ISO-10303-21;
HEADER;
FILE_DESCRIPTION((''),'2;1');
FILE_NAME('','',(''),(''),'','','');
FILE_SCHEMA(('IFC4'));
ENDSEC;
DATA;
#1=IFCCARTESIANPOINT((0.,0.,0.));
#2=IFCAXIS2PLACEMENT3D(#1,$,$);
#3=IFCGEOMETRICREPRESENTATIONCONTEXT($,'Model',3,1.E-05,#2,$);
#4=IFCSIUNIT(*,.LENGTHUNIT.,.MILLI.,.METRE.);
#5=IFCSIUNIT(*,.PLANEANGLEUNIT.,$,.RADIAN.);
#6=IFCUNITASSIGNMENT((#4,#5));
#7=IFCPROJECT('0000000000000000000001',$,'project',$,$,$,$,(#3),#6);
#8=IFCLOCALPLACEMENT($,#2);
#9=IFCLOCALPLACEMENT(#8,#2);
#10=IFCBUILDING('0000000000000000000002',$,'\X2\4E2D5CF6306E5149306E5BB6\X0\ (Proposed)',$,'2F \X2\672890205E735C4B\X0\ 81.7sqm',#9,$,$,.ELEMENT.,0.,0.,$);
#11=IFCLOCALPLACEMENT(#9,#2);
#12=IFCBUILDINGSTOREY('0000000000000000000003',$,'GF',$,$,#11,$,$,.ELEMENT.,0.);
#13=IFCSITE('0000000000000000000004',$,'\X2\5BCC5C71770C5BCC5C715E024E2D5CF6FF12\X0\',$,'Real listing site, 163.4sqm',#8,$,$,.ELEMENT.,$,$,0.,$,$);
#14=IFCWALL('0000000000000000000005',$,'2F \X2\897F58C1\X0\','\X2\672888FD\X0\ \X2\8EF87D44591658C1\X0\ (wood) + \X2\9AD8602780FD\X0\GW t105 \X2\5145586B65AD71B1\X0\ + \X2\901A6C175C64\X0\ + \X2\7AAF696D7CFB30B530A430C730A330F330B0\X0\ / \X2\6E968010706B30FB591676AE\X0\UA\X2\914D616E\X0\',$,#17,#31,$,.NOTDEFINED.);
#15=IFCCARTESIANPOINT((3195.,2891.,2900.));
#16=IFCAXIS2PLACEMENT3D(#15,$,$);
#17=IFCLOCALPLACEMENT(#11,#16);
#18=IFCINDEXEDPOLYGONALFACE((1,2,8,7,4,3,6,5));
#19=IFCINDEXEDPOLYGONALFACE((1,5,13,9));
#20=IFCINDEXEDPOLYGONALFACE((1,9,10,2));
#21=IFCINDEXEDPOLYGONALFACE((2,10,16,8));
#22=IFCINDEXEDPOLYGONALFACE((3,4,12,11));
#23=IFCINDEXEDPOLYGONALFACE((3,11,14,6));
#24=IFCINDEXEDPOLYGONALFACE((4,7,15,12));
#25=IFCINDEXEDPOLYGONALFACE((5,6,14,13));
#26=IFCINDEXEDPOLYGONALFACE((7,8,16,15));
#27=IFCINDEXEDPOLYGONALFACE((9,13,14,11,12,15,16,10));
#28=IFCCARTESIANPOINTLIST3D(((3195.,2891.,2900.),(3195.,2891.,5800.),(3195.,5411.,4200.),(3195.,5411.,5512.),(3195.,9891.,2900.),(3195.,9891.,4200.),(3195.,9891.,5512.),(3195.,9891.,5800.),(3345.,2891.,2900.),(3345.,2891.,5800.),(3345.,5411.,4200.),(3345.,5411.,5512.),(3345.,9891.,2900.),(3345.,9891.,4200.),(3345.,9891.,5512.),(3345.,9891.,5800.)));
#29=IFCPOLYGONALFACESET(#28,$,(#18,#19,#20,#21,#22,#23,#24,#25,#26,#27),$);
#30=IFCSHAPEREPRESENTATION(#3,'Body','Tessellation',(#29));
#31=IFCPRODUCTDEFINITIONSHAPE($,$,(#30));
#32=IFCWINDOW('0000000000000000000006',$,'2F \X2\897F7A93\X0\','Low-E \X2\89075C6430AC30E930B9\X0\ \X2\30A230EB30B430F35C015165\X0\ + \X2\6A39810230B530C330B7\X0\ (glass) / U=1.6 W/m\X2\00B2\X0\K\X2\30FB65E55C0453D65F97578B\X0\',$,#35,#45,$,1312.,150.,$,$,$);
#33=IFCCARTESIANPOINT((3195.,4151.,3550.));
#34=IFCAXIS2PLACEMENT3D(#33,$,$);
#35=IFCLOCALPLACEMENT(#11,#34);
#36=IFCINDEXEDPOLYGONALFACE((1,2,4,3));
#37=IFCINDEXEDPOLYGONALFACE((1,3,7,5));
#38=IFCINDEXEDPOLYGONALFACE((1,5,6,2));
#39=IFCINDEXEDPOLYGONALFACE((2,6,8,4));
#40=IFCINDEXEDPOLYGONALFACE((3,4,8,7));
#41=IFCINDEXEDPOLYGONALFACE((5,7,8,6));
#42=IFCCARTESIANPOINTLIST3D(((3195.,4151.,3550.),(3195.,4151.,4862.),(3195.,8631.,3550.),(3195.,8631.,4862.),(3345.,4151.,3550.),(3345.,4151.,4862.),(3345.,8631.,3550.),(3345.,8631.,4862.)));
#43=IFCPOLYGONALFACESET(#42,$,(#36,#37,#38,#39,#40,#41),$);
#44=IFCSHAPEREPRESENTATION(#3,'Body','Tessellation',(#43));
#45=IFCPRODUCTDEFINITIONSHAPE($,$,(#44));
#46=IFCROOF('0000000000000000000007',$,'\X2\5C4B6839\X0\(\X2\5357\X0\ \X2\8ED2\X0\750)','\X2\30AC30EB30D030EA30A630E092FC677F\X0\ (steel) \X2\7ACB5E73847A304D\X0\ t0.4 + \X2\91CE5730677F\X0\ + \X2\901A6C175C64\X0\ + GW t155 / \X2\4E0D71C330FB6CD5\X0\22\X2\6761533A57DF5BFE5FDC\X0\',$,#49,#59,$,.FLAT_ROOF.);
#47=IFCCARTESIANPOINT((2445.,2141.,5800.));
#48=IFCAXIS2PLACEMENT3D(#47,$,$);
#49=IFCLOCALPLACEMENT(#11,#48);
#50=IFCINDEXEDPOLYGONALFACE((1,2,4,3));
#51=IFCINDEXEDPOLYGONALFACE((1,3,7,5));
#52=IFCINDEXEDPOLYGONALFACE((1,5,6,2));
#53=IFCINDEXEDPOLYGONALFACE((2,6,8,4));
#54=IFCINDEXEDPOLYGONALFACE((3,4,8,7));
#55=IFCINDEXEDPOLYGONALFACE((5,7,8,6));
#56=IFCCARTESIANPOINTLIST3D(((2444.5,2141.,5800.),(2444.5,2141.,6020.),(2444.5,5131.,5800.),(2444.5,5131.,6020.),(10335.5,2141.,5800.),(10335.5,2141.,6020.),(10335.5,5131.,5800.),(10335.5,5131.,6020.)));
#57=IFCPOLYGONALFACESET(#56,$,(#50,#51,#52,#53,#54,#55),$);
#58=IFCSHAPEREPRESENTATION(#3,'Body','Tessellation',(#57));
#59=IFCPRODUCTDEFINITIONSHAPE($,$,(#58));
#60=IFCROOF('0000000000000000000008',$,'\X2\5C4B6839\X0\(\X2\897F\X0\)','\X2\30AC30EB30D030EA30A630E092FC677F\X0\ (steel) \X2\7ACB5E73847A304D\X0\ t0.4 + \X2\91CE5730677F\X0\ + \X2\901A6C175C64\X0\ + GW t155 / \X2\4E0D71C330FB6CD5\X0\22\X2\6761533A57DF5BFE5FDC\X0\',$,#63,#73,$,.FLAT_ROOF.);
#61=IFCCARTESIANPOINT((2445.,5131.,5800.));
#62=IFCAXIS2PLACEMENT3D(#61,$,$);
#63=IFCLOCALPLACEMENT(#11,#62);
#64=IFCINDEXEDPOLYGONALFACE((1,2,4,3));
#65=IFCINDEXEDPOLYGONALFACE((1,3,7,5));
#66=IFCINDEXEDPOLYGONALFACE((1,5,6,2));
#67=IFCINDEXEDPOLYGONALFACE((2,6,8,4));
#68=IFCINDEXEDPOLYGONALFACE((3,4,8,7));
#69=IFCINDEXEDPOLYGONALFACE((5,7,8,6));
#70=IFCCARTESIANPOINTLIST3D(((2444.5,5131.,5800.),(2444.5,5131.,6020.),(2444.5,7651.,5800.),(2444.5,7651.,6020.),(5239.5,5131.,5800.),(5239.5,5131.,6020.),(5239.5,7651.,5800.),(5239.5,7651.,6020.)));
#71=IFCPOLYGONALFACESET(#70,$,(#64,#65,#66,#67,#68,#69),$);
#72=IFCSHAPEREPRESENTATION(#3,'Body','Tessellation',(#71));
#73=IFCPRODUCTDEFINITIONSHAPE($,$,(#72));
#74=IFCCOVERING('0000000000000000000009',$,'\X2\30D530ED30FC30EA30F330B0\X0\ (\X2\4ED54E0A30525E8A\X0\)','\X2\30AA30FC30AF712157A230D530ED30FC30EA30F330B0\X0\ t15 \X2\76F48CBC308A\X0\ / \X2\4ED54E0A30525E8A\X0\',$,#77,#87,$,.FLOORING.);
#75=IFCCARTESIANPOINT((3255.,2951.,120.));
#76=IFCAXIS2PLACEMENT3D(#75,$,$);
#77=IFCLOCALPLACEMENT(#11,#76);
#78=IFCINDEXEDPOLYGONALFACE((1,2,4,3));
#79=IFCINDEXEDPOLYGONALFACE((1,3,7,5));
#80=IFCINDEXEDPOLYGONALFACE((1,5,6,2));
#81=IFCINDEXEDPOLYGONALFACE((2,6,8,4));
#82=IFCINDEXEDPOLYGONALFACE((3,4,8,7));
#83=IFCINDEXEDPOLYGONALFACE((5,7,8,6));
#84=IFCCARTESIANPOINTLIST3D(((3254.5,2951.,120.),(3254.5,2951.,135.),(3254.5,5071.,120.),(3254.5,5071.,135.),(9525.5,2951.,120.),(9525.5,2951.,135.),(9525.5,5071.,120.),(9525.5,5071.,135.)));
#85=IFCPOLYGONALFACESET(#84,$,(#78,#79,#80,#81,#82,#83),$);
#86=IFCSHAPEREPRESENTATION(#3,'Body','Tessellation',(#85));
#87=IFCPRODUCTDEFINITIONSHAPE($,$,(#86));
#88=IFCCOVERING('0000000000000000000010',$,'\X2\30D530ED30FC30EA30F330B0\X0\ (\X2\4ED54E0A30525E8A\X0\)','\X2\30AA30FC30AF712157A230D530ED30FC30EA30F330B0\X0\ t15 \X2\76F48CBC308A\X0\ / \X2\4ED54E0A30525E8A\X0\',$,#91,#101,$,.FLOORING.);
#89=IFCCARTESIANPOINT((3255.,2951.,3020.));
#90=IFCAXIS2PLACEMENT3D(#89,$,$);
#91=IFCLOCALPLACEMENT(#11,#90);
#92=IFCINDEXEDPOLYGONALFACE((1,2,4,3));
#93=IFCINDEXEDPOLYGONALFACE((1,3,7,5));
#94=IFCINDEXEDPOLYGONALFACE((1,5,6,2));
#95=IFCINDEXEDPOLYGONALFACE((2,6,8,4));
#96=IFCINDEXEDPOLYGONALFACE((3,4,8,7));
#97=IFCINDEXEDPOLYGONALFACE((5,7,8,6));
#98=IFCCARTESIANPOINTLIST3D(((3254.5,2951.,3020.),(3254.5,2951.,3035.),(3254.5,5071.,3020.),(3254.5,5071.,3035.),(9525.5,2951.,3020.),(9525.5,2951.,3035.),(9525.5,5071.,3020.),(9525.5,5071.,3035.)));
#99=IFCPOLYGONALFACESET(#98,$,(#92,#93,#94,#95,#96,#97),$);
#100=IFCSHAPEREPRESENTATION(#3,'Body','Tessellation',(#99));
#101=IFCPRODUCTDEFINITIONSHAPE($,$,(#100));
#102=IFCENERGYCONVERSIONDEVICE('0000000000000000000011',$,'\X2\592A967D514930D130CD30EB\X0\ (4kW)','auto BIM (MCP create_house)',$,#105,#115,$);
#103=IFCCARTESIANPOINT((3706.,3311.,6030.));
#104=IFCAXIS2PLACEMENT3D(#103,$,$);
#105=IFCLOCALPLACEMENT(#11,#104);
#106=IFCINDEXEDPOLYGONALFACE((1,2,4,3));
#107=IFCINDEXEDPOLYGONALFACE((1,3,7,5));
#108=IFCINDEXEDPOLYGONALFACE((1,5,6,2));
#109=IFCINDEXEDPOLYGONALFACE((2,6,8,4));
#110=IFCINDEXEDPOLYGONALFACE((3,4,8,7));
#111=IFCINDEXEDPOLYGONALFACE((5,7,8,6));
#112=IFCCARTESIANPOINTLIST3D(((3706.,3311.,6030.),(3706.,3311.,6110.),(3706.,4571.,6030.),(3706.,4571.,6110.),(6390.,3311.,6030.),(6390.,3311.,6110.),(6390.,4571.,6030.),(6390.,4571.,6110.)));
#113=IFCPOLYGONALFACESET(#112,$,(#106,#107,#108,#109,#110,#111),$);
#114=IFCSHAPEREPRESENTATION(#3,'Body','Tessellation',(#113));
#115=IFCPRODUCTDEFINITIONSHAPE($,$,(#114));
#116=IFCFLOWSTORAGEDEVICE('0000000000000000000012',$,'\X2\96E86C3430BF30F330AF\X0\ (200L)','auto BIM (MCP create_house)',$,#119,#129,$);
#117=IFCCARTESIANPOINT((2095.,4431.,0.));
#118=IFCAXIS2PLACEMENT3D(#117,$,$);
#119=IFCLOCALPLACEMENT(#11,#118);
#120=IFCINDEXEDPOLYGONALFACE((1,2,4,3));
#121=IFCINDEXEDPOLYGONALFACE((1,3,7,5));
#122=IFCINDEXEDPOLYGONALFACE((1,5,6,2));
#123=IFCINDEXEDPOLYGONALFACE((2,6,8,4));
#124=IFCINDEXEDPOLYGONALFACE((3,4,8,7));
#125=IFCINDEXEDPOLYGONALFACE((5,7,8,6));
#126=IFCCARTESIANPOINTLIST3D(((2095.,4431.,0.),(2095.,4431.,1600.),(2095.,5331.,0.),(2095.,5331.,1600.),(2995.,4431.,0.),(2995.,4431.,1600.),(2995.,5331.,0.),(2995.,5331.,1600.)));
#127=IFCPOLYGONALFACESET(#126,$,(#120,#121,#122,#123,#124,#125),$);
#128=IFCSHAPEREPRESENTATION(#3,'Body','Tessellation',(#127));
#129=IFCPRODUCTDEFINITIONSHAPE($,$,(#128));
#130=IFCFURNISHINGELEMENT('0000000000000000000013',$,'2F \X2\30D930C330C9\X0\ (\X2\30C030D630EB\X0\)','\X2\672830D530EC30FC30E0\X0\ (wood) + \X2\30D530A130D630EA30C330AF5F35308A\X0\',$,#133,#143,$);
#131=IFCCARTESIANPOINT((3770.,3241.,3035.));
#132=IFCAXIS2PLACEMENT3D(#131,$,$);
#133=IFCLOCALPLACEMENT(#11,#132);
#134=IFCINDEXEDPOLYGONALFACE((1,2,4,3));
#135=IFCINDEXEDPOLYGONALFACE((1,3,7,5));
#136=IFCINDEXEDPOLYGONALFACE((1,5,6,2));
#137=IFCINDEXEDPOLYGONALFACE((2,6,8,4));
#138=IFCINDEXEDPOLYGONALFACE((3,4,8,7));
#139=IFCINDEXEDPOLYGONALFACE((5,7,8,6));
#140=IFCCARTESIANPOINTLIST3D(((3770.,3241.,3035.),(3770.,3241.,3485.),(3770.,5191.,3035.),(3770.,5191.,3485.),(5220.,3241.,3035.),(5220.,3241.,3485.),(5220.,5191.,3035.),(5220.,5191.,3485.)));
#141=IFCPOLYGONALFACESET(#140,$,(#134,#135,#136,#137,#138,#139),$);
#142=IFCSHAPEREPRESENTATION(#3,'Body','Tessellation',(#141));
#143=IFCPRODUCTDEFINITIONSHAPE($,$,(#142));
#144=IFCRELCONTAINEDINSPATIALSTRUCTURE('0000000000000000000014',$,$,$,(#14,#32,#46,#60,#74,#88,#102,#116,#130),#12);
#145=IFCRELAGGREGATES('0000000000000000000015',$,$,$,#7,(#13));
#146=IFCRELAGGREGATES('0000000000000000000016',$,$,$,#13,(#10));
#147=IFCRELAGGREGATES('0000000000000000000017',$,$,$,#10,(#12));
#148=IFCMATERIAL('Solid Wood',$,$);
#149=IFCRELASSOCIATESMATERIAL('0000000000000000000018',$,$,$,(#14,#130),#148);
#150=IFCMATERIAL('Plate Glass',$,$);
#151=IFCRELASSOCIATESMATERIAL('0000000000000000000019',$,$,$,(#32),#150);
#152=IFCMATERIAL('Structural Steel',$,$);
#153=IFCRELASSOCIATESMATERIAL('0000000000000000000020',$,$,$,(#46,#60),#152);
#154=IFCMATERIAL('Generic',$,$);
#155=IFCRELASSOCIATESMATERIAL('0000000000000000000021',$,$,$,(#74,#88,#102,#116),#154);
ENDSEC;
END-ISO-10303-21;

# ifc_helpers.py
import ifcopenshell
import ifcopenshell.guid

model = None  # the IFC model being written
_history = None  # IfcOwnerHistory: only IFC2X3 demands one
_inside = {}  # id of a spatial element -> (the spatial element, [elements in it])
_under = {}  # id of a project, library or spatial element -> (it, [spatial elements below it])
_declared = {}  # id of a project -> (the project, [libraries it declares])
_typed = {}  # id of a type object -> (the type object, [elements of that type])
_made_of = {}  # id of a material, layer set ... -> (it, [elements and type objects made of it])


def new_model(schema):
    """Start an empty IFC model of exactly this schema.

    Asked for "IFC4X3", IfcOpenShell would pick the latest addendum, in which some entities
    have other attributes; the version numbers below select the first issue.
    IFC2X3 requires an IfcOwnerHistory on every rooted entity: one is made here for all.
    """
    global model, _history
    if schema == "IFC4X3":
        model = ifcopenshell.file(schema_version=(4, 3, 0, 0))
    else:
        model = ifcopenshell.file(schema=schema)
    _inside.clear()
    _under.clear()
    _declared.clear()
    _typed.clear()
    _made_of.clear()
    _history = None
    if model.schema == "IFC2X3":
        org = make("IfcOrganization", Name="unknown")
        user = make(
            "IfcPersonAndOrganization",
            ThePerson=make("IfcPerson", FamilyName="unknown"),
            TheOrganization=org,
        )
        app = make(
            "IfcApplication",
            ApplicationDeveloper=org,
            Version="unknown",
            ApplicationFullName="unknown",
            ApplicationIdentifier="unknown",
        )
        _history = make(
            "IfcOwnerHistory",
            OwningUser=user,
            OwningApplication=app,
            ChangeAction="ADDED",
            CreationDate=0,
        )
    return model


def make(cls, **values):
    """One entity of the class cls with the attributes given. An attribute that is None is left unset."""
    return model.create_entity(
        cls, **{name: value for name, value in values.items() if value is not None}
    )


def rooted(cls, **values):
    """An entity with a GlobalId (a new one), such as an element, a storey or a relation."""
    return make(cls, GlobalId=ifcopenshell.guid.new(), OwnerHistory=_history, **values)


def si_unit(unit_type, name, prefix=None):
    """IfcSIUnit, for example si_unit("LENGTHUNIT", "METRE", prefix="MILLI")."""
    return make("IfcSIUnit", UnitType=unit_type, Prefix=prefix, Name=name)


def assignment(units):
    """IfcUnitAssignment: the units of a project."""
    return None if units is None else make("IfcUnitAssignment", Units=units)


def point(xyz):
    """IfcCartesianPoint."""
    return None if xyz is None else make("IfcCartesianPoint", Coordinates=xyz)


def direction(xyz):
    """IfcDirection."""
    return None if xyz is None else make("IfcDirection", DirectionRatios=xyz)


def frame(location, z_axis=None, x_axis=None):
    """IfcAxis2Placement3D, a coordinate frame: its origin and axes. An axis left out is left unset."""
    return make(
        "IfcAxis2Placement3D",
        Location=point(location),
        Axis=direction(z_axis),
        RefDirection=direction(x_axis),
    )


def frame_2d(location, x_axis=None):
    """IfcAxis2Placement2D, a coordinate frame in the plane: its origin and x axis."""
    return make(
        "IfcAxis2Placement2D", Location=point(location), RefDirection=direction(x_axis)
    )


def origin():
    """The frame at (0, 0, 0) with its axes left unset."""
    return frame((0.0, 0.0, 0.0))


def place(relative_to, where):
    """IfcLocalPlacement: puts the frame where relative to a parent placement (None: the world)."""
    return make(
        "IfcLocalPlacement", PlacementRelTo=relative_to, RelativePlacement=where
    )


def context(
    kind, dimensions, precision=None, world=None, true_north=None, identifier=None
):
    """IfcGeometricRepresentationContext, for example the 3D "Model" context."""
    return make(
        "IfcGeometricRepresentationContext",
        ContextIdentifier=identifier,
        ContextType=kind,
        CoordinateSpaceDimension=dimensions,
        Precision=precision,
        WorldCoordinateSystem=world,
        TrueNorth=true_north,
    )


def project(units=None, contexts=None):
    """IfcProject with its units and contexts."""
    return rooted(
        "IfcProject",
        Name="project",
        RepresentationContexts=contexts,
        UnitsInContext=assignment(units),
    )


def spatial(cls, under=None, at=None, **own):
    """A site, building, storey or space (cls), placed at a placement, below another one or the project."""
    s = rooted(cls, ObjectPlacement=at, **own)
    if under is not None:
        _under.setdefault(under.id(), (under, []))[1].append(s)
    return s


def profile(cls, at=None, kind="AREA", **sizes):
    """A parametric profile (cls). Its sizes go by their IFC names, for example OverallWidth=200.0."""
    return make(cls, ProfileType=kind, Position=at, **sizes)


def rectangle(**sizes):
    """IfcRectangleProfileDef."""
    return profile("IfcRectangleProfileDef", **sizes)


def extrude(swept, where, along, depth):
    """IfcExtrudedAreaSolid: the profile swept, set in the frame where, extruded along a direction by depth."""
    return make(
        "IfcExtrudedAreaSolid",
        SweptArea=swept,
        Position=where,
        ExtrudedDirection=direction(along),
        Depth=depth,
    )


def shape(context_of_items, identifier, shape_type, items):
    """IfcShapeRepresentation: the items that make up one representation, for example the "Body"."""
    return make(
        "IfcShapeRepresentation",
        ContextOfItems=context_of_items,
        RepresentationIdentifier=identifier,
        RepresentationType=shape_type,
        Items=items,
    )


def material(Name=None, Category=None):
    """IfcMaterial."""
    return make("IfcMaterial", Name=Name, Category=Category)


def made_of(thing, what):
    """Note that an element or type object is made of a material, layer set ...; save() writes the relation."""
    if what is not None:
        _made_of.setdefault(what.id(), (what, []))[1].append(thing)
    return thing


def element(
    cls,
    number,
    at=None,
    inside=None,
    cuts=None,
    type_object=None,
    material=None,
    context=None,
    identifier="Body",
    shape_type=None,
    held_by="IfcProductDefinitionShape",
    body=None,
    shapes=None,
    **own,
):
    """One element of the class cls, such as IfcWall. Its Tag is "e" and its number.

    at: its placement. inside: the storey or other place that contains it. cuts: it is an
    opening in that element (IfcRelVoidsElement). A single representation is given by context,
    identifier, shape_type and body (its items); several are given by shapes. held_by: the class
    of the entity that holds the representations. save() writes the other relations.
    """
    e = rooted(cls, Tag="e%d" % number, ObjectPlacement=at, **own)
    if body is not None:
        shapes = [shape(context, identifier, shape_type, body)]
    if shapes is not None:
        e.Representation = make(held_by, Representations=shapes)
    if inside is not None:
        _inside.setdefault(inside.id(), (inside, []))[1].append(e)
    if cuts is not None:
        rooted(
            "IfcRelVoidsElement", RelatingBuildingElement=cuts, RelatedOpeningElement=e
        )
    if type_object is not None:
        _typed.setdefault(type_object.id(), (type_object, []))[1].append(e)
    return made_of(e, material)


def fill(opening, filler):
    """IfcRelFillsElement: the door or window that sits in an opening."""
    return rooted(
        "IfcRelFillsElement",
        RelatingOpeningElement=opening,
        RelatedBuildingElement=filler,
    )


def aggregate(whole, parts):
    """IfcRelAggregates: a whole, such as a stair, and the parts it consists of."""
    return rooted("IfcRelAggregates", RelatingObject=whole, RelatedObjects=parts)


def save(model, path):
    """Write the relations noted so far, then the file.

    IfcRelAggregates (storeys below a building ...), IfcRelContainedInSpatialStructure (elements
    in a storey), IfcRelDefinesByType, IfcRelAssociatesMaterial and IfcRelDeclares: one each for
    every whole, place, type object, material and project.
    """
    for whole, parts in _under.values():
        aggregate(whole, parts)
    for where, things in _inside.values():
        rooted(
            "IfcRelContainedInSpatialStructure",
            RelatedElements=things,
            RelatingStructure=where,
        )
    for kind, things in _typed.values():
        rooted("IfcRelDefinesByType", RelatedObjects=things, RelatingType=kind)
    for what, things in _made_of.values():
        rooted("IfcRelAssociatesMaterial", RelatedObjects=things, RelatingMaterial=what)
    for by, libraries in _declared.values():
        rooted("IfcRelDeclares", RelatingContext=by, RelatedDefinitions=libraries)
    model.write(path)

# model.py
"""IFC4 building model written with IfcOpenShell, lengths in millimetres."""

from ifc_helpers import new_model, si_unit, frame, frame_2d, origin, place, context, project, spatial, rectangle, extrude, material, element, fill, save


model = new_model("IFC4")

# Units and contexts
model_context = context("Model", 3, precision=1e-05, world=origin())
ifc_project = project(units=[si_unit("LENGTHUNIT", "METRE", prefix="MILLI"), si_unit("PLANEANGLEUNIT", "RADIAN")], contexts=[model_context])

# Site, building, storey
site_placement = place(None, origin())
site = spatial("IfcSite", under=ifc_project, at=site_placement, Name="富山県富山市中島２", ObjectType="Real listing site, 163.4sqm", CompositionType="ELEMENT", RefElevation=0.0)
building_placement = place(site_placement, origin())
building = spatial("IfcBuilding", under=site, at=building_placement, Name="中島の光の家 (Proposed)", ObjectType="2F 木造平屋 81.7sqm", CompositionType="ELEMENT", ElevationOfRefHeight=0.0, ElevationOfTerrain=0.0)
storey_placement = place(building_placement, origin())
storey = spatial("IfcBuildingStorey", under=building, at=storey_placement, Name="GF", CompositionType="ELEMENT", Elevation=0.0)

# Shared definitions
ifc_material_1 = material(Name="Solid Wood")

# Shared definitions
ifc_material_2 = material(Name="Plate Glass")

# Wall, opening, window
wall_1_placement = place(storey_placement, frame((3195.0, 2891.0, 2900.0)))
wall_1 = element("IfcWall", 1, at=wall_1_placement, inside=storey, material=ifc_material_1, Name="2F 西壁", Description="木製 軸組外壁 (wood) + 高性能GW t105 充填断熱 + 通気層 + 窯業系サイディング / 準耐火・外皮UA配慮", PredefinedType="NOTDEFINED", context=model_context, shape_type="SweptSolid", body=[
    extrude(rectangle(XDim=150.0, YDim=7000.0, at=frame_2d((75.0, 3500.0))), frame((3195.0, 2891.0, 2900.0)), (0.0, 0.0, 1.0), 2900.0),
])
opening_1_placement = place(storey_placement, frame((3195.0, 4151.0, 3550.0)))
opening_1 = element("IfcOpeningElement", 2, at=opening_1_placement, cuts=wall_1, PredefinedType="NOTDEFINED", context=model_context, shape_type="SweptSolid", body=[
    extrude(rectangle(XDim=150.0, YDim=4480.0, at=frame_2d((75.0, 2240.0))), frame((3195.0, 4151.0, 3550.0)), (0.0, 0.0, 1.0), 1312.0),
])
window_1_placement = place(storey_placement, frame((3195.0, 4151.0, 3550.0)))
window_1 = element("IfcWindow", 3, at=window_1_placement, inside=storey, material=ifc_material_2, Name="2F 西窓", Description="Low-E 複層ガラス アルゴン封入 + 樹脂サッシ (glass) / U=1.6 W/m²K・日射取得型", OverallHeight=1312.0, OverallWidth=150.0, context=model_context, shape_type="SweptSolid", body=[
    extrude(rectangle(XDim=150.0, YDim=4480.0, at=frame_2d((75.0, 2240.0))), frame((3195.0, 4151.0, 3550.0)), (0.0, 0.0, 1.0), 1312.0),
])
fill(opening_1, window_1)

# Roofs
ifc_material_3 = material(Name="Structural Steel")
roof_1_placement = place(storey_placement, frame((2445.0, 2141.0, 5800.0)))
element("IfcRoof", 4, at=roof_1_placement, inside=storey, material=ifc_material_3, Name="屋根(南 軒750)", Description="ガルバリウム鋼板 (steel) 立平葺き t0.4 + 野地板 + 通気層 + GW t155 / 不燃・法22条区域対応", PredefinedType="FLAT_ROOF", context=model_context, shape_type="SweptSolid", body=[
    extrude(rectangle(XDim=7891.0, YDim=2990.0, at=frame_2d((3945.0, 1495.0))), frame((2445.0, 2141.0, 5800.0)), (0.0, 0.0, 1.0), 220.0),
])
roof_2_placement = place(storey_placement, frame((2445.0, 5131.0, 5800.0)))
element("IfcRoof", 5, at=roof_2_placement, inside=storey, material=ifc_material_3, Name="屋根(西)", Description="ガルバリウム鋼板 (steel) 立平葺き t0.4 + 野地板 + 通気層 + GW t155 / 不燃・法22条区域対応", PredefinedType="FLAT_ROOF", context=model_context, shape_type="SweptSolid", body=[
    extrude(rectangle(XDim=2795.0, YDim=2520.0, at=frame_2d((1397.0, 1260.0))), frame((2445.0, 5131.0, 5800.0)), (0.0, 0.0, 1.0), 220.0),
])

# Coverings
ifc_material_4 = material(Name="Generic")
covering_1_placement = place(storey_placement, frame((3255.0, 2951.0, 120.0)))
element("IfcCovering", 6, at=covering_1_placement, inside=storey, material=ifc_material_4, Name="フローリング (仕上げ床)", Description="オーク無垢フローリング t15 直貼り / 仕上げ床", PredefinedType="FLOORING", context=model_context, shape_type="SweptSolid", body=[
    extrude(rectangle(XDim=6271.0, YDim=2120.0, at=frame_2d((3135.0, 1060.0))), frame((3255.0, 2951.0, 120.0)), (0.0, 0.0, 1.0), 15.0),
])
covering_2_placement = place(storey_placement, frame((3255.0, 2951.0, 3020.0)))
element("IfcCovering", 7, at=covering_2_placement, inside=storey, material=ifc_material_4, Name="フローリング (仕上げ床)", Description="オーク無垢フローリング t15 直貼り / 仕上げ床", PredefinedType="FLOORING", context=model_context, shape_type="SweptSolid", body=[
    extrude(rectangle(XDim=6271.0, YDim=2120.0, at=frame_2d((3135.0, 1060.0))), frame((3255.0, 2951.0, 3020.0)), (0.0, 0.0, 1.0), 15.0),
])

# Energy conversion device
energy_conversion_device_placement = place(storey_placement, frame((3706.0, 3311.0, 6030.0)))
element("IfcEnergyConversionDevice", 8, at=energy_conversion_device_placement, inside=storey, material=ifc_material_4, Name="太陽光パネル (4kW)", Description="auto BIM (MCP create_house)", context=model_context, shape_type="SweptSolid", body=[
    extrude(rectangle(XDim=2684.0, YDim=1260.0, at=frame_2d((1342.0, 630.0))), frame((3706.0, 3311.0, 6030.0)), (0.0, 0.0, 1.0), 80.0),
])

# Flow storage device
flow_storage_device_placement = place(storey_placement, frame((2095.0, 4431.0, 0.0)))
element("IfcFlowStorageDevice", 9, at=flow_storage_device_placement, inside=storey, material=ifc_material_4, Name="雨水タンク (200L)", Description="auto BIM (MCP create_house)", context=model_context, shape_type="SweptSolid", body=[
    extrude(rectangle(XDim=900.0, YDim=900.0, at=frame_2d((450.0, 450.0))), frame((2095.0, 4431.0, 0.0)), (0.0, 0.0, 1.0), 1600.0),
])

# Furnishing element
furnishing_placement = place(storey_placement, frame((3770.0, 3241.0, 3035.0)))
element("IfcFurnishingElement", 10, at=furnishing_placement, inside=storey, material=ifc_material_1, Name="2F ベッド (ダブル)", Description="木フレーム (wood) + ファブリック張り", context=model_context, shape_type="SweptSolid", body=[
    extrude(rectangle(XDim=1450.0, YDim=1950.0, at=frame_2d((725.0, 975.0))), frame((3770.0, 3241.0, 3035.0)), (0.0, 0.0, 1.0), 450.0),
])

save(model, "model.ifc")
